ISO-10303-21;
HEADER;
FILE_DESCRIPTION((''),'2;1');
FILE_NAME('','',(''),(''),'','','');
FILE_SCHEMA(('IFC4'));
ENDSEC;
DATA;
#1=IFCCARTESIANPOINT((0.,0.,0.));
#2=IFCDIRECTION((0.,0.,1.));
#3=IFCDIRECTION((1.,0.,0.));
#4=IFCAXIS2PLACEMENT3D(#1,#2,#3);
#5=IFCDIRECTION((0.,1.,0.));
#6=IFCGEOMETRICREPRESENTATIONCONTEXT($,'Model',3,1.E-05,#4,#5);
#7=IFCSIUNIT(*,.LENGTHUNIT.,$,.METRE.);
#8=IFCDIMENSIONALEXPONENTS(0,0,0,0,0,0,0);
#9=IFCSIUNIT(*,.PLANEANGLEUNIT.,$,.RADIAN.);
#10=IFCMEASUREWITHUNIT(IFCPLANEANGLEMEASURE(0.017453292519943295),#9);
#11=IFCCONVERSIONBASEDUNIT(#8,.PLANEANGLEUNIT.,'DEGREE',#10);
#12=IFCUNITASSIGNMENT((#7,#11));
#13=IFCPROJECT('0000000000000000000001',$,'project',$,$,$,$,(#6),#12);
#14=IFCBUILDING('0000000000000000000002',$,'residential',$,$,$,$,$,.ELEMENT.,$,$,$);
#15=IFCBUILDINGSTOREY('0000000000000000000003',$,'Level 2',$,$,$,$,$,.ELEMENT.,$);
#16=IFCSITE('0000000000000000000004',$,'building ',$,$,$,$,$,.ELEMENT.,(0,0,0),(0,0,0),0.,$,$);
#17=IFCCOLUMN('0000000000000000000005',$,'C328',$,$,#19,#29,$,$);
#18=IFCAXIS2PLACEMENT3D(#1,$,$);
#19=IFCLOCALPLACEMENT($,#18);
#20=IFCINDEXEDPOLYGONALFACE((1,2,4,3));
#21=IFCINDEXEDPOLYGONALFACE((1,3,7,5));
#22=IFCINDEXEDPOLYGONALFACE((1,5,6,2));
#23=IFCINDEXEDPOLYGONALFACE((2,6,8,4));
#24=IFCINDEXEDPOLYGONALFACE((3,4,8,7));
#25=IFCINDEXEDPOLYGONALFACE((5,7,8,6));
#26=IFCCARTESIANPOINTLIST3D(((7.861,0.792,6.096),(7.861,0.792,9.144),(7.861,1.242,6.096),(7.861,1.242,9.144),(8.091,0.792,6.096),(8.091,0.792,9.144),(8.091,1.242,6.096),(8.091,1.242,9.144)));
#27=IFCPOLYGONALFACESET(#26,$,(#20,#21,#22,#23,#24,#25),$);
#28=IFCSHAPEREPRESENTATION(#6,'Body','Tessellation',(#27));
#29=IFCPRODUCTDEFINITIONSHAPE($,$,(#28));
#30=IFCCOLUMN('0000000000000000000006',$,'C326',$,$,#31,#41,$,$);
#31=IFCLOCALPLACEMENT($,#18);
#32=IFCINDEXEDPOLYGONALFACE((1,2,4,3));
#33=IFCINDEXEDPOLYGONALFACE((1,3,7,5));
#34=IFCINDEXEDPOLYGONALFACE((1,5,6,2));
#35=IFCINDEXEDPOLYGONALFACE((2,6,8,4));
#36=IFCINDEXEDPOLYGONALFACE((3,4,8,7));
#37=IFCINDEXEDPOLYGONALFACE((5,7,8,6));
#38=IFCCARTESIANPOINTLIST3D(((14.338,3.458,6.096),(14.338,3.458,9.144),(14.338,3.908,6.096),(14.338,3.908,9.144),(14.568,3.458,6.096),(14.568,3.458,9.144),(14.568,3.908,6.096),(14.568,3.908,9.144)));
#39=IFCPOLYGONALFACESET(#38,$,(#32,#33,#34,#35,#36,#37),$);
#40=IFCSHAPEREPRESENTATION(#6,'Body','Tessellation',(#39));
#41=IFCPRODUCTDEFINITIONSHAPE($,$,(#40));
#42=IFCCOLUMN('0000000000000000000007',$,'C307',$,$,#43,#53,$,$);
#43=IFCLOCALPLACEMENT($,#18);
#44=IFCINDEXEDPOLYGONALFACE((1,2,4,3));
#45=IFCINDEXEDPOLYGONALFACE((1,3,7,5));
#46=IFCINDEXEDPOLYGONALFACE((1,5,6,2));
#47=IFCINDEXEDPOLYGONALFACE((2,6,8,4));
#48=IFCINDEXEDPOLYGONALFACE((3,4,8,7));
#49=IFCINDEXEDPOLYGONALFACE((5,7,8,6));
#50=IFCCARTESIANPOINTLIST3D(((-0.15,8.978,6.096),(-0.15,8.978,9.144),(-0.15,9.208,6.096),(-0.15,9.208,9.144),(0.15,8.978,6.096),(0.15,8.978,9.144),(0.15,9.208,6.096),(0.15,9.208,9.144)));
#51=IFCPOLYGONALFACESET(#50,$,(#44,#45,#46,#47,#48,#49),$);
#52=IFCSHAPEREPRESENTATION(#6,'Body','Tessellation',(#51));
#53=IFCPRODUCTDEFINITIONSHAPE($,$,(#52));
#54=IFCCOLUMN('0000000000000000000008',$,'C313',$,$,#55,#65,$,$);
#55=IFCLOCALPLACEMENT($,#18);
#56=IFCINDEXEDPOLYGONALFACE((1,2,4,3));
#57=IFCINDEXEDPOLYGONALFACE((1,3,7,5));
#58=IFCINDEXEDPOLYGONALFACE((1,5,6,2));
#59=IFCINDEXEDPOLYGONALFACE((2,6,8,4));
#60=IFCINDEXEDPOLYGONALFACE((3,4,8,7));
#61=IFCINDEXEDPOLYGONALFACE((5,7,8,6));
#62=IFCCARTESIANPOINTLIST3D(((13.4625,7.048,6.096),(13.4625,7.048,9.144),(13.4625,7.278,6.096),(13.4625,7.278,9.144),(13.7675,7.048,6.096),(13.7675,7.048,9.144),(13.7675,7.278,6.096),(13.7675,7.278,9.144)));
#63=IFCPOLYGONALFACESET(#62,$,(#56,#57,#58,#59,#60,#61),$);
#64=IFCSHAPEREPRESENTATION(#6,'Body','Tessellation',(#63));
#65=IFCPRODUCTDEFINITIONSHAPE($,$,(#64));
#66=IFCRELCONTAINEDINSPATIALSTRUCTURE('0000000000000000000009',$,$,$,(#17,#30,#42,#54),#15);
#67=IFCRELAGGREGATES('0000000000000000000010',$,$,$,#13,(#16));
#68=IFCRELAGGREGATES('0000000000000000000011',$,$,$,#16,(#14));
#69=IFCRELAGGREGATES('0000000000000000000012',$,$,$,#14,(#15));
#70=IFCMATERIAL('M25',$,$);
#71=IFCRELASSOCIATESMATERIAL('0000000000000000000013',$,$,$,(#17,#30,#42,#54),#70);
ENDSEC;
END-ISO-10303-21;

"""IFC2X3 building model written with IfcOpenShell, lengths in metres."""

from ifc_helpers import new_model, entity, si_unit, converted_unit, direction, frame, frame_2d, origin_with_axes, place, context, project, spatial, rectangle, extrude, material, element, save


model = new_model("IFC2X3")

# Units and contexts
model_context = context("Model", 3, precision=1e-05, world=origin_with_axes(), true_north=direction((0.0, 1.0, 0.0)))
ifc_project = project(units=[si_unit("LENGTHUNIT", "METRE"), converted_unit("PLANEANGLEUNIT", "DEGREE", entity("IfcPlaneAngleMeasure", 0.017453292519943295), si_unit("PLANEANGLEUNIT", "RADIAN"), dimensions=[0, 0, 0, 0, 0, 0, 0])], contexts=[model_context])

# Site, building, storey
site = spatial("IfcSite", under=ifc_project, Name="building ", CompositionType="ELEMENT", RefLatitude=(0, 0, 0), RefLongitude=(0, 0, 0), RefElevation=0.0)
building = spatial("IfcBuilding", under=site, Name="residential", CompositionType="ELEMENT")
storey = spatial("IfcBuildingStorey", under=building, Name="Level 2", CompositionType="ELEMENT")

# Columns
ifc_material = material(Name="M25")
placement = place(None, origin_with_axes())
element("IfcColumn", 1, at=placement, inside=storey, material=ifc_material, Name="C328", context=model_context, shape_type="SweptSolid", body=[
    extrude(rectangle(XDim=0.23, YDim=0.45, at=frame_2d((0.0, 0.0), x_axis=(1.0, 0.0, 0.0))), frame((7.976, 1.017, 6.096), z_axis=(0.0, 0.0, 1.0), x_axis=(1.0, 0.0, 0.0)), (0.0, 0.0, 1.0), 3.048),
])
element("IfcColumn", 2, at=placement, inside=storey, material=ifc_material, Name="C326", context=model_context, shape_type="SweptSolid", body=[
    extrude(rectangle(XDim=0.23, YDim=0.45, at=frame_2d((0.0, 0.0), x_axis=(1.0, 0.0, 0.0))), frame((14.453, 3.683, 6.096), z_axis=(0.0, 0.0, 1.0), x_axis=(1.0, 0.0, 0.0)), (0.0, 0.0, 1.0), 3.048),
])
element("IfcColumn", 3, at=placement, inside=storey, material=ifc_material, Name="C307", context=model_context, shape_type="SweptSolid", body=[
    extrude(rectangle(XDim=0.3, YDim=0.23, at=frame_2d((0.0, 0.0), x_axis=(1.0, 0.0, 0.0))), frame((0.0, 9.093, 6.096), z_axis=(0.0, 0.0, 1.0), x_axis=(1.0, 0.0, 0.0)), (0.0, 0.0, 1.0), 3.048),
])
element("IfcColumn", 4, at=placement, inside=storey, material=ifc_material, Name="C313", context=model_context, shape_type="SweptSolid", body=[
    extrude(rectangle(XDim=0.305, YDim=0.23, at=frame_2d((0.0, 0.0), x_axis=(1.0, 0.0, 0.0))), frame((13.615, 7.163, 6.096), z_axis=(0.0, 0.0, 1.0), x_axis=(1.0, 0.0, 0.0)), (0.0, 0.0, 1.0), 3.048),
])

save(model, "model.ifc")
